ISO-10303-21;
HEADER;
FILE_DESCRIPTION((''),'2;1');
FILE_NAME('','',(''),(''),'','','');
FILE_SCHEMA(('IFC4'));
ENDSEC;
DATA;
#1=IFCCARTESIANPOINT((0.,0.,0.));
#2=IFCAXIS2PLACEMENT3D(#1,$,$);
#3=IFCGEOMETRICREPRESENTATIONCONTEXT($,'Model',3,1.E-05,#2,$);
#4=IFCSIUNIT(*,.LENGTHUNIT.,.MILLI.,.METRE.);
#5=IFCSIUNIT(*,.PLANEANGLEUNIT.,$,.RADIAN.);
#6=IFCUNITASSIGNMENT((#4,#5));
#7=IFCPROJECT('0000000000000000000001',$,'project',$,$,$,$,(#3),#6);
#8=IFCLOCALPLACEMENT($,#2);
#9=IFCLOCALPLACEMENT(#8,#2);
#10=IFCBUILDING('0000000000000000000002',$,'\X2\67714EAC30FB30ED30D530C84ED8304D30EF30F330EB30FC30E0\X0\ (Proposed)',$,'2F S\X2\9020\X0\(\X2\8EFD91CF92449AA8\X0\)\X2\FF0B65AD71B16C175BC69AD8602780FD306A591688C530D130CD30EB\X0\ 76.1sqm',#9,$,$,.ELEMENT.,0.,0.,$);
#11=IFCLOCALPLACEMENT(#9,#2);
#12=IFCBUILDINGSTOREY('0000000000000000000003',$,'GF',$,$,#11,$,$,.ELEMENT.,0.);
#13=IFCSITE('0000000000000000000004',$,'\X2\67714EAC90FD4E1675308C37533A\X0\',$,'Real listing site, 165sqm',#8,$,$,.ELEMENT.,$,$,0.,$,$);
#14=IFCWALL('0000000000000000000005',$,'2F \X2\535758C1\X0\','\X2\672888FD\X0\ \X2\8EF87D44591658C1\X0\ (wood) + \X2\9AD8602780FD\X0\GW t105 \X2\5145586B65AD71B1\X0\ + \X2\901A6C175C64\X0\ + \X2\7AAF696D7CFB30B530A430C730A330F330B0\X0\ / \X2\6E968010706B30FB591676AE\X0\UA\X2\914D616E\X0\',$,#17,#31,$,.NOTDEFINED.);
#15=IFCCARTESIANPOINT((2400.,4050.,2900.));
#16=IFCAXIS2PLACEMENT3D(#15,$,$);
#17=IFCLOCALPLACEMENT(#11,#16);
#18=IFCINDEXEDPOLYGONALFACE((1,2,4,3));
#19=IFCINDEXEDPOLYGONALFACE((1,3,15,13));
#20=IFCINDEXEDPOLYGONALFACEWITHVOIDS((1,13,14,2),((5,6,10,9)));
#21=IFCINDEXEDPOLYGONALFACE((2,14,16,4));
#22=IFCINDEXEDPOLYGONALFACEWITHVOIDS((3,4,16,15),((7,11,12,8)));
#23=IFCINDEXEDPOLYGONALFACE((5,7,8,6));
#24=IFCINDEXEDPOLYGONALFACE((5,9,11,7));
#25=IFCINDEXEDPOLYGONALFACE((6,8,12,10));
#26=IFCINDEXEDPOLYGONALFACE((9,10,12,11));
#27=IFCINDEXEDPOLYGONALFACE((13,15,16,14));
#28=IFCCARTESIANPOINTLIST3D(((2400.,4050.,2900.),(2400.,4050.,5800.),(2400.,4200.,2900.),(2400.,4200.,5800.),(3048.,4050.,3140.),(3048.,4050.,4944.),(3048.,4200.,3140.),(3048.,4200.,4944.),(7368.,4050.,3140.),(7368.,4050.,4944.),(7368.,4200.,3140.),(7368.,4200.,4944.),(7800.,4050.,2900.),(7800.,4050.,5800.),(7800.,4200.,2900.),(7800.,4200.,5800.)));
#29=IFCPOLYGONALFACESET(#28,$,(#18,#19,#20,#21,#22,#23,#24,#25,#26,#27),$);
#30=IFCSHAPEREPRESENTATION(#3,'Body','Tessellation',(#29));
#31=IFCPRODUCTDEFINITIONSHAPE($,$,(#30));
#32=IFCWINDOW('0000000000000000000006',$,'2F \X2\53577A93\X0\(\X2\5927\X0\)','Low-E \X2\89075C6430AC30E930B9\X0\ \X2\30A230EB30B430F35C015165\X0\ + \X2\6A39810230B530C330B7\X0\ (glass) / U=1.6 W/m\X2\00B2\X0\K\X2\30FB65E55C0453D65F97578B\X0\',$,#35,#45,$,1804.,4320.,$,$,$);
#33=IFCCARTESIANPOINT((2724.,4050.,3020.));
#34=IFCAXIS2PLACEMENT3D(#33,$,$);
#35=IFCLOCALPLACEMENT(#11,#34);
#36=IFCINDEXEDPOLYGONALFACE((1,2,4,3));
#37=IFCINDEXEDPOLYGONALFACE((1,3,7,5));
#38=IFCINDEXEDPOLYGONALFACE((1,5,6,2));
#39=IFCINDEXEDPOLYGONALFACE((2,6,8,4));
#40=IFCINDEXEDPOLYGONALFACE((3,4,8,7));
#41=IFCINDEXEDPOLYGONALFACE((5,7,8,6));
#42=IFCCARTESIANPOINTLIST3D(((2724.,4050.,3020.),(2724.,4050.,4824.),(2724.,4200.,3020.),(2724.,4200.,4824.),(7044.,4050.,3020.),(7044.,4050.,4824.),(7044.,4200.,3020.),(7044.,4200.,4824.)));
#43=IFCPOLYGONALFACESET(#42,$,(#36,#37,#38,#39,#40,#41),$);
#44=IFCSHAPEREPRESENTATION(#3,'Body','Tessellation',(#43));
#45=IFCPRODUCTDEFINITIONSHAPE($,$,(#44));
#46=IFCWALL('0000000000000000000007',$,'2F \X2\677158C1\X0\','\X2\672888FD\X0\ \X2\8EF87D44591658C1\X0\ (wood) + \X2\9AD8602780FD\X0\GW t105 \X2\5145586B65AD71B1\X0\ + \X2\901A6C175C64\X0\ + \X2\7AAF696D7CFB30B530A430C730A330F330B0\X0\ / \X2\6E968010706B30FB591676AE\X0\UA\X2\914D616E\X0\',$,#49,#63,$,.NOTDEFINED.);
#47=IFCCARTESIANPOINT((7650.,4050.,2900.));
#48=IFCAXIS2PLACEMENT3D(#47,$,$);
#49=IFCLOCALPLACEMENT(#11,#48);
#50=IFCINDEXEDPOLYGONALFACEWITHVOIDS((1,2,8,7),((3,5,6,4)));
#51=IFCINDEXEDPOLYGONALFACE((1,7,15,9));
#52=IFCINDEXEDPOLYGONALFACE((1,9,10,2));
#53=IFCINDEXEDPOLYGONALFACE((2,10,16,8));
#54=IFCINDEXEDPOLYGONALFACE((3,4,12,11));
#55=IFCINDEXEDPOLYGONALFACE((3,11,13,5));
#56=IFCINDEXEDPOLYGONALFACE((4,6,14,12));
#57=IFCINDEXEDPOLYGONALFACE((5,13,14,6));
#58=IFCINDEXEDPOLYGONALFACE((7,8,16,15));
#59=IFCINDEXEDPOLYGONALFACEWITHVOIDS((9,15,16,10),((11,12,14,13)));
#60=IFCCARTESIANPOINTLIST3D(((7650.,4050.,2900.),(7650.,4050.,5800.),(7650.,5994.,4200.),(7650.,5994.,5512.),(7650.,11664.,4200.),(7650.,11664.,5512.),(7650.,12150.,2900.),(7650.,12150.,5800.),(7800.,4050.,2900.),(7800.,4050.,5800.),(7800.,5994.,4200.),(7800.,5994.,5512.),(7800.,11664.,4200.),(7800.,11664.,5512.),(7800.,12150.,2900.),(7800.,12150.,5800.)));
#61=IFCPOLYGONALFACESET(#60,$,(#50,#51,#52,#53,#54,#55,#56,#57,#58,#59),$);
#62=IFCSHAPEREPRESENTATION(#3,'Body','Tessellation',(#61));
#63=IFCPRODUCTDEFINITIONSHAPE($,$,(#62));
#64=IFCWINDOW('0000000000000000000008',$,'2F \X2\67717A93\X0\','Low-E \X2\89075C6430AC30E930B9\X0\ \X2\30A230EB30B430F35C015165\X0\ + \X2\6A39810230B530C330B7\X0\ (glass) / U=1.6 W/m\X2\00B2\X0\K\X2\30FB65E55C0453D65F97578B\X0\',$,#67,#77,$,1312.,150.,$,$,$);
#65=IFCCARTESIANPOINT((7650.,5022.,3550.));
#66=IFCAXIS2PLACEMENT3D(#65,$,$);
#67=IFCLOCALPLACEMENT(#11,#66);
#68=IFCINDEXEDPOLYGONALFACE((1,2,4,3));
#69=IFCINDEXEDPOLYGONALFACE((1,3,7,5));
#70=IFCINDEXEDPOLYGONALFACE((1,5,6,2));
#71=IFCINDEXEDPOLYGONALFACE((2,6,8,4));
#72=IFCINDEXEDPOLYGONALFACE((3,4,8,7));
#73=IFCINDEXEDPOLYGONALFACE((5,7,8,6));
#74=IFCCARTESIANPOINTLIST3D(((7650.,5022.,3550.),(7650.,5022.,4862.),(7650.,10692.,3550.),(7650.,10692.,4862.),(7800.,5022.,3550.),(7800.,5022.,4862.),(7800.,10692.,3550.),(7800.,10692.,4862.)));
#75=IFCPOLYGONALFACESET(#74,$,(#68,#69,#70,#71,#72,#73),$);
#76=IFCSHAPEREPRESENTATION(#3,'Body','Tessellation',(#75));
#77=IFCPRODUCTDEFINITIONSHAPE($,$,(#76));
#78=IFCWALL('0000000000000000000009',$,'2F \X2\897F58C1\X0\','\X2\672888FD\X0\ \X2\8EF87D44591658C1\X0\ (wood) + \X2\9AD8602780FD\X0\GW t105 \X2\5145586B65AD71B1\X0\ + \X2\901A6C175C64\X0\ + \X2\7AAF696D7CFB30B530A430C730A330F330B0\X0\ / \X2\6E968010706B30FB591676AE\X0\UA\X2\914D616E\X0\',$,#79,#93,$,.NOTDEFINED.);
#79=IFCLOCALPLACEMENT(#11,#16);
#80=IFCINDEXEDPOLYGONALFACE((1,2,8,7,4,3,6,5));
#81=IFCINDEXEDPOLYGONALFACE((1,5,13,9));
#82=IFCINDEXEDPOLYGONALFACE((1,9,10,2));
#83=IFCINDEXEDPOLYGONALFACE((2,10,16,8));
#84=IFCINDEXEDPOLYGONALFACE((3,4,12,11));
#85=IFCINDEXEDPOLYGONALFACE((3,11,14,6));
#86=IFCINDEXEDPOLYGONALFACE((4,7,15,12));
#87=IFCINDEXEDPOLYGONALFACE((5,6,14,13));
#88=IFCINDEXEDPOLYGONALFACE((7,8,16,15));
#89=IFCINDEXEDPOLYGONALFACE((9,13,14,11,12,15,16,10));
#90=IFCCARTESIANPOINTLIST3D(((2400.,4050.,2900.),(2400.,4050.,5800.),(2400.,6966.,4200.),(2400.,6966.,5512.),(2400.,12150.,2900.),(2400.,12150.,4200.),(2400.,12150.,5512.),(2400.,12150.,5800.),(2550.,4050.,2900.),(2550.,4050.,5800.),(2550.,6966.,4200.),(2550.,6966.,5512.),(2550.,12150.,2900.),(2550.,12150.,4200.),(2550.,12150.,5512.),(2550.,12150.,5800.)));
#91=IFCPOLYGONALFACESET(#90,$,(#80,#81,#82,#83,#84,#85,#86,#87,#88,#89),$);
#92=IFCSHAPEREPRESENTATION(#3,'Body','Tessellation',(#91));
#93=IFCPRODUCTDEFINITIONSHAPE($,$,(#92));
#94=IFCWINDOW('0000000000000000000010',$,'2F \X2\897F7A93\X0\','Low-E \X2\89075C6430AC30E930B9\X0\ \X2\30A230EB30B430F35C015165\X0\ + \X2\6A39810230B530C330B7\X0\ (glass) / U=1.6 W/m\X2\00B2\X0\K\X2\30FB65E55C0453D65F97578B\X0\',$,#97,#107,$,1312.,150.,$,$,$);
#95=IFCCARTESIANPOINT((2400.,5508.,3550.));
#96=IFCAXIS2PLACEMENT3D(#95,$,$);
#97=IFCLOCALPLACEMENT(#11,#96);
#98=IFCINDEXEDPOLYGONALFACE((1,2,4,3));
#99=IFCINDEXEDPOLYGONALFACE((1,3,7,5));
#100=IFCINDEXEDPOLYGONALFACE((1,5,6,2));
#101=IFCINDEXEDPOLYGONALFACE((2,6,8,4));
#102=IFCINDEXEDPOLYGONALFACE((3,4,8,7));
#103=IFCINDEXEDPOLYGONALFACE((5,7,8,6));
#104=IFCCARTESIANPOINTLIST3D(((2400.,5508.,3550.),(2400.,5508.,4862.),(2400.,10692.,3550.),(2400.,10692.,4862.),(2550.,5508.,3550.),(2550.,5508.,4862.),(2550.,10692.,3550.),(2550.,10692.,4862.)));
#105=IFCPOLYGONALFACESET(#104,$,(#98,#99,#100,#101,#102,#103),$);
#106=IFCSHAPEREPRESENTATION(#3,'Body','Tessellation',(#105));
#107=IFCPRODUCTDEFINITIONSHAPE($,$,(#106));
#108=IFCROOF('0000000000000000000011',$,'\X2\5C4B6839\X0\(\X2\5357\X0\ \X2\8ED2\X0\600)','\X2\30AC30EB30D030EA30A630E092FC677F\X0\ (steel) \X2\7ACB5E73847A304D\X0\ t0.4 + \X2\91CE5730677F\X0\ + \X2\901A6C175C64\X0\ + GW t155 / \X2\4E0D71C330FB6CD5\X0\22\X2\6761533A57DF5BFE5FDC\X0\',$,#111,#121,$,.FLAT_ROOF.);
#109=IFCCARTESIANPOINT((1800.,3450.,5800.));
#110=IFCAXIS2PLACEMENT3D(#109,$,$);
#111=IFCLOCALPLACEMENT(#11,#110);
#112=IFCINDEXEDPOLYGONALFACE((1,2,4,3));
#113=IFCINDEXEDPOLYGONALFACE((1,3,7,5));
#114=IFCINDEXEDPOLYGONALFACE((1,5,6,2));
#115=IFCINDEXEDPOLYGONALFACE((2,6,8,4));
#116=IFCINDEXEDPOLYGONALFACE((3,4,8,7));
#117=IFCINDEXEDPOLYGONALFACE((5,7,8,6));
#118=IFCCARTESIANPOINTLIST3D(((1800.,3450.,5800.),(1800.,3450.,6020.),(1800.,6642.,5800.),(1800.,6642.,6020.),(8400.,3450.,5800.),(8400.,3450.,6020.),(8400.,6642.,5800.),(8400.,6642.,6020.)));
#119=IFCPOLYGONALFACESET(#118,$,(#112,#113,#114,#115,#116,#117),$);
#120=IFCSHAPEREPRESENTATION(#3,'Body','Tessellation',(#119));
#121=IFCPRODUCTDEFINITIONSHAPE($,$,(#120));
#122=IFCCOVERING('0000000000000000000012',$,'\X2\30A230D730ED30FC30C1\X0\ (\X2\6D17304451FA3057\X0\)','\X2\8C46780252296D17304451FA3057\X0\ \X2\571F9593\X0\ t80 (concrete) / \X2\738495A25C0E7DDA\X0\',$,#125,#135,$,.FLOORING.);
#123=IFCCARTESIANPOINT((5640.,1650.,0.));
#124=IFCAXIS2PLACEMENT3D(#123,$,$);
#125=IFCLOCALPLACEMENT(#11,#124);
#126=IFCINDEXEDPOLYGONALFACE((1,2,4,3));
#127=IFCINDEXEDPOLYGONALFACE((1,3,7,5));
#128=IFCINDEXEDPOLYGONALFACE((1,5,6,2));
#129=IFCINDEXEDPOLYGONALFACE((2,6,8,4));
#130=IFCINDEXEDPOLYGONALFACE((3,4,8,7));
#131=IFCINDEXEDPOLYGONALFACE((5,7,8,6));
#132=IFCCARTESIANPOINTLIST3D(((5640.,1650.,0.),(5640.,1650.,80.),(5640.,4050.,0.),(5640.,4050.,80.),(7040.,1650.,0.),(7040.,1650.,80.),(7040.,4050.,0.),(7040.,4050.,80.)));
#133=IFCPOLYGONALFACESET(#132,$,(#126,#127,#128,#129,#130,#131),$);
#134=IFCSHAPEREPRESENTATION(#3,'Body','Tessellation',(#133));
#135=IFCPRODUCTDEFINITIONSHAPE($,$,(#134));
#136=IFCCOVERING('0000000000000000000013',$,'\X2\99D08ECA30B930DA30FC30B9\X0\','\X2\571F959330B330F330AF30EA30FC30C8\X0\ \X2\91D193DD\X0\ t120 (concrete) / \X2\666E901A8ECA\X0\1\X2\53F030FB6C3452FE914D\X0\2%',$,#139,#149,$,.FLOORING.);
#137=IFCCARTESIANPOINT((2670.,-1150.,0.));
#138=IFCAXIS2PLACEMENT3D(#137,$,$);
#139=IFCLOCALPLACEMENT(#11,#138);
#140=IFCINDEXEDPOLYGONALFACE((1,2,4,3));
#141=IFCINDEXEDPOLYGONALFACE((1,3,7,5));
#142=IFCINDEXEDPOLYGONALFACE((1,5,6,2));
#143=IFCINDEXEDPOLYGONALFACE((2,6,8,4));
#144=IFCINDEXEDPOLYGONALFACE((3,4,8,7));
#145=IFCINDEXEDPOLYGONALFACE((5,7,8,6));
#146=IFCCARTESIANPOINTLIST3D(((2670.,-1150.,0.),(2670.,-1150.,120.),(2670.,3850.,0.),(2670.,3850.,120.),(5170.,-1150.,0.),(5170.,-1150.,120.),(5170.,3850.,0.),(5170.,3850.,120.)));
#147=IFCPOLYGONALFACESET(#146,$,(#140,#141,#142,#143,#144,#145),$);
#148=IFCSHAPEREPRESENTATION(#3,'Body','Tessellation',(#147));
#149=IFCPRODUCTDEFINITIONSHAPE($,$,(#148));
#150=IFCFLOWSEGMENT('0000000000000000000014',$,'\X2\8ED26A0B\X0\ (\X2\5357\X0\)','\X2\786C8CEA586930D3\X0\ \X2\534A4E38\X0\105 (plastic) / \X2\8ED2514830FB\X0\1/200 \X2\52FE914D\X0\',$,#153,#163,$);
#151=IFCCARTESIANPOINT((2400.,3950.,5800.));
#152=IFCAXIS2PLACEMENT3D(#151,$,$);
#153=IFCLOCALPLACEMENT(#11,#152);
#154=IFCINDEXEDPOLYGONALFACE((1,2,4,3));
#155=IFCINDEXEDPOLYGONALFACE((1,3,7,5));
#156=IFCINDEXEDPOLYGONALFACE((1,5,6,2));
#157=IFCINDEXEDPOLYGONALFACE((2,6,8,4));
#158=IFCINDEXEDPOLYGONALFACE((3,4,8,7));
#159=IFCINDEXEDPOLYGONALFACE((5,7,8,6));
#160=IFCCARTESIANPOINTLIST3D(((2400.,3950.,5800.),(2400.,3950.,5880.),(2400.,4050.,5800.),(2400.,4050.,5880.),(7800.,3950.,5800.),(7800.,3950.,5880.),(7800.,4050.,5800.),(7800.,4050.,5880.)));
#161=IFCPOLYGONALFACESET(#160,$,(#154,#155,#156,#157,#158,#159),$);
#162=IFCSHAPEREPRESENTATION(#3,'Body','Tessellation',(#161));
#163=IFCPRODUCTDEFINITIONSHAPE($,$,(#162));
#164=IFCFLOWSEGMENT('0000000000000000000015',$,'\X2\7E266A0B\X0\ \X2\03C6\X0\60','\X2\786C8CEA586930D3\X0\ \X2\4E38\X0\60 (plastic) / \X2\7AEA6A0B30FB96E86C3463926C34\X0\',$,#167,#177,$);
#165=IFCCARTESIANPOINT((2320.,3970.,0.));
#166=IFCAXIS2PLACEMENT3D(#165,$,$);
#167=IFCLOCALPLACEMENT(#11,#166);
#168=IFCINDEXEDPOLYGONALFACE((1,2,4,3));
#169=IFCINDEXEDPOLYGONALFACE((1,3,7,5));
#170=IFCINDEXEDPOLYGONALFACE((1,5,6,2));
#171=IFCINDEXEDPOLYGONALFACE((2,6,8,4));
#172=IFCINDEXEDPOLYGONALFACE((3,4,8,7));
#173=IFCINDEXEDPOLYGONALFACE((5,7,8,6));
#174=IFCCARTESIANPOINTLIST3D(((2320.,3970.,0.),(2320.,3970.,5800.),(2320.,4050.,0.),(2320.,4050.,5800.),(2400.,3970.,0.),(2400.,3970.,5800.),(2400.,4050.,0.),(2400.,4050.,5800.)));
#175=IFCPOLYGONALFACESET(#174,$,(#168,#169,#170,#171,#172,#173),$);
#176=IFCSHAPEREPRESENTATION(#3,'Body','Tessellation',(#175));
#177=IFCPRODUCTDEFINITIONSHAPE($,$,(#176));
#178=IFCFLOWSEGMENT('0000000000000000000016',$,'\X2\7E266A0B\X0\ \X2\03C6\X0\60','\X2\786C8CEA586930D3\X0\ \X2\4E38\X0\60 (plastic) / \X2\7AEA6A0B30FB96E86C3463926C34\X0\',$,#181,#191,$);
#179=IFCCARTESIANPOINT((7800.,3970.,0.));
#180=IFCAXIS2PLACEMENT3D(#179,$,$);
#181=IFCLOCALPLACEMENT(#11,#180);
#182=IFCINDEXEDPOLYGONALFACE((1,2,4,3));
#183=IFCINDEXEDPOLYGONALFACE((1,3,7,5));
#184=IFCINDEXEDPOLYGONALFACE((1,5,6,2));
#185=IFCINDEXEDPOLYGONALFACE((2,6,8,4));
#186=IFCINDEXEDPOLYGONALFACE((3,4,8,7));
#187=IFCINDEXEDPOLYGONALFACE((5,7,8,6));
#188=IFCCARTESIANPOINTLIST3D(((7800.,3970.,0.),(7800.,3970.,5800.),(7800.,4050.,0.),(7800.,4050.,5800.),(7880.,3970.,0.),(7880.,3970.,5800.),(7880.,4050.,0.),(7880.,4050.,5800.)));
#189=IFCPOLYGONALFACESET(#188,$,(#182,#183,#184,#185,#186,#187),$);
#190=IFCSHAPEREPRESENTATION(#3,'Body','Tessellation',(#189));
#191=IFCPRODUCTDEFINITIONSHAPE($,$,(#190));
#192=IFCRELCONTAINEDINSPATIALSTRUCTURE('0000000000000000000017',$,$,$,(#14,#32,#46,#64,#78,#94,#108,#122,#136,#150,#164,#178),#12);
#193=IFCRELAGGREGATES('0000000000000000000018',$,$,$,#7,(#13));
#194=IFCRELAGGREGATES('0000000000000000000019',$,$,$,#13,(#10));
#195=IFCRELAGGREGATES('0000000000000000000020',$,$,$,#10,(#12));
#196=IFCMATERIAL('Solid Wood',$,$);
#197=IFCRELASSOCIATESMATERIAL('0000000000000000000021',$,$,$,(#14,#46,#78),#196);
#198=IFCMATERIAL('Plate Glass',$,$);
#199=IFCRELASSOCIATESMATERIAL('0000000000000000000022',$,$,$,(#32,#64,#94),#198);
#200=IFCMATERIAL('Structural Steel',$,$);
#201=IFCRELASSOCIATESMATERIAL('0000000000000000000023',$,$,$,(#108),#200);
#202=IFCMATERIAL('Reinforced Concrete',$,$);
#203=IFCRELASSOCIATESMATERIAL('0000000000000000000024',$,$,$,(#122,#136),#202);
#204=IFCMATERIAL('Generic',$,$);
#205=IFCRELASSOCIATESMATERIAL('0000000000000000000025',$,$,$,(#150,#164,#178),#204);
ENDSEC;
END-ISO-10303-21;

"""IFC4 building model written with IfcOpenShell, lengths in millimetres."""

from ifc_helpers import new_model, si_unit, frame, frame_2d, origin, place, context, project, spatial, rectangle, extrude, material, element, fill, save


model = new_model("IFC4")

# Units and contexts
model_context = context("Model", 3, precision=1e-05, world=origin())
ifc_project = project(units=[si_unit("LENGTHUNIT", "METRE", prefix="MILLI"), si_unit("PLANEANGLEUNIT", "RADIAN")], contexts=[model_context])

# Site, building, storey
site_placement = place(None, origin())
site = spatial("IfcSite", under=ifc_project, at=site_placement, Name="東京都世田谷区", ObjectType="Real listing site, 165sqm", CompositionType="ELEMENT", RefElevation=0.0)
building_placement = place(site_placement, origin())
building = spatial("IfcBuilding", under=site, at=building_placement, Name="東京・ロフト付きワンルーム (Proposed)", ObjectType="2F S造(軽量鉄骨)＋断熱気密高性能な外装パネル 76.1sqm", CompositionType="ELEMENT", ElevationOfRefHeight=0.0, ElevationOfTerrain=0.0)
storey_placement = place(building_placement, origin())
storey = spatial("IfcBuildingStorey", under=building, at=storey_placement, Name="GF", CompositionType="ELEMENT", Elevation=0.0)

# Shared definitions
ifc_material_1 = material(Name="Solid Wood")

# Shared definitions
ifc_material_2 = material(Name="Reinforced Concrete")

# Shared definitions
ifc_material_3 = material(Name="Plate Glass")

# Walls, openings, windows
wall_1_placement = place(storey_placement, frame((2400.0, 4050.0, 2900.0)))
wall_1 = element("IfcWall", 1, at=wall_1_placement, inside=storey, material=ifc_material_1, Name="2F 南壁", Description="木製 軸組外壁 (wood) + 高性能GW t105 充填断熱 + 通気層 + 窯業系サイディング / 準耐火・外皮UA配慮", PredefinedType="NOTDEFINED", context=model_context, shape_type="SweptSolid", body=[
    extrude(rectangle(XDim=5400.0, YDim=150.0, at=frame_2d((2700.0, 75.0))), frame((2400.0, 4050.0, 2900.0)), (0.0, 0.0, 1.0), 2900.0),
])
opening_1_placement = place(storey_placement, frame((2724.0, 4050.0, 3020.0)))
opening_1 = element("IfcOpeningElement", 2, at=opening_1_placement, cuts=wall_1, PredefinedType="NOTDEFINED", context=model_context, shape_type="SweptSolid", body=[
    extrude(rectangle(XDim=4320.0, YDim=150.0, at=frame_2d((2160.0, 75.0))), frame((2724.0, 4050.0, 3020.0)), (0.0, 0.0, 1.0), 1804.0),
])
window_1_placement = place(storey_placement, frame((2724.0, 4050.0, 3020.0)))
window_1 = element("IfcWindow", 3, at=window_1_placement, inside=storey, material=ifc_material_3, Name="2F 南窓(大)", Description="Low-E 複層ガラス アルゴン封入 + 樹脂サッシ (glass) / U=1.6 W/m²K・日射取得型", OverallHeight=1804.0, OverallWidth=4320.0, context=model_context, shape_type="SweptSolid", body=[
    extrude(rectangle(XDim=4320.0, YDim=150.0, at=frame_2d((2160.0, 75.0))), frame((2724.0, 4050.0, 3020.0)), (0.0, 0.0, 1.0), 1804.0),
])
fill(opening_1, window_1)
wall_2_placement = place(storey_placement, frame((7650.0, 4050.0, 2900.0)))
wall_2 = element("IfcWall", 4, at=wall_2_placement, inside=storey, material=ifc_material_1, Name="2F 東壁", Description="木製 軸組外壁 (wood) + 高性能GW t105 充填断熱 + 通気層 + 窯業系サイディング / 準耐火・外皮UA配慮", PredefinedType="NOTDEFINED", context=model_context, shape_type="SweptSolid", body=[
    extrude(rectangle(XDim=150.0, YDim=8100.0, at=frame_2d((75.0, 4050.0))), frame((7650.0, 4050.0, 2900.0)), (0.0, 0.0, 1.0), 2900.0),
])
opening_2_placement = place(storey_placement, frame((7650.0, 5022.0, 3550.0)))
opening_2 = element("IfcOpeningElement", 5, at=opening_2_placement, cuts=wall_2, PredefinedType="NOTDEFINED", context=model_context, shape_type="SweptSolid", body=[
    extrude(rectangle(XDim=150.0, YDim=5670.0, at=frame_2d((75.0, 2835.0))), frame((7650.0, 5022.0, 3550.0)), (0.0, 0.0, 1.0), 1312.0),
])
window_2_placement = place(storey_placement, frame((7650.0, 5022.0, 3550.0)))
window_2 = element("IfcWindow", 6, at=window_2_placement, inside=storey, material=ifc_material_3, Name="2F 東窓", Description="Low-E 複層ガラス アルゴン封入 + 樹脂サッシ (glass) / U=1.6 W/m²K・日射取得型", OverallHeight=1312.0, OverallWidth=150.0, context=model_context, shape_type="SweptSolid", body=[
    extrude(rectangle(XDim=150.0, YDim=5670.0, at=frame_2d((75.0, 2835.0))), frame((7650.0, 5022.0, 3550.0)), (0.0, 0.0, 1.0), 1312.0),
])
fill(opening_2, window_2)
wall_3_placement = place(storey_placement, frame((2400.0, 4050.0, 2900.0)))
wall_3 = element("IfcWall", 7, at=wall_3_placement, inside=storey, material=ifc_material_1, Name="2F 西壁", Description="木製 軸組外壁 (wood) + 高性能GW t105 充填断熱 + 通気層 + 窯業系サイディング / 準耐火・外皮UA配慮", PredefinedType="NOTDEFINED", context=model_context, shape_type="SweptSolid", body=[
    extrude(rectangle(XDim=150.0, YDim=8100.0, at=frame_2d((75.0, 4050.0))), frame((2400.0, 4050.0, 2900.0)), (0.0, 0.0, 1.0), 2900.0),
])
opening_3_placement = place(storey_placement, frame((2400.0, 5508.0, 3550.0)))
opening_3 = element("IfcOpeningElement", 8, at=opening_3_placement, cuts=wall_3, PredefinedType="NOTDEFINED", context=model_context, shape_type="SweptSolid", body=[
    extrude(rectangle(XDim=150.0, YDim=5184.0, at=frame_2d((75.0, 2592.0))), frame((2400.0, 5508.0, 3550.0)), (0.0, 0.0, 1.0), 1312.0),
])
window_3_placement = place(storey_placement, frame((2400.0, 5508.0, 3550.0)))
window_3 = element("IfcWindow", 9, at=window_3_placement, inside=storey, material=ifc_material_3, Name="2F 西窓", Description="Low-E 複層ガラス アルゴン封入 + 樹脂サッシ (glass) / U=1.6 W/m²K・日射取得型", OverallHeight=1312.0, OverallWidth=150.0, context=model_context, shape_type="SweptSolid", body=[
    extrude(rectangle(XDim=150.0, YDim=5184.0, at=frame_2d((75.0, 2592.0))), frame((2400.0, 5508.0, 3550.0)), (0.0, 0.0, 1.0), 1312.0),
])
fill(opening_3, window_3)

# Roof
ifc_material_4 = material(Name="Structural Steel")
for number, where, name in (
    (10, (1800.0, 3450.0, 5800.0), "屋根(南 軒600)"),
):
    element("IfcRoof", number, at=place(storey_placement, frame(where)), inside=storey, material=ifc_material_4, Name=name, Description="ガルバリウム鋼板 (steel) 立平葺き t0.4 + 野地板 + 通気層 + GW t155 / 不燃・法22条区域対応", PredefinedType="FLAT_ROOF", context=model_context, shape_type="SweptSolid", body=[
        extrude(rectangle(XDim=6600.0, YDim=3192.0, at=frame_2d((3300.0, 1596.0))), frame((1800.0, 3450.0, 5800.0)), (0.0, 0.0, 1.0), 220.0),
    ])

# Coverings
covering_1_placement = place(storey_placement, frame((5640.0, 1650.0, 0.0)))
element("IfcCovering", 11, at=covering_1_placement, inside=storey, material=ifc_material_2, Name="アプローチ (洗い出し)", Description="豆砂利洗い出し 土間 t80 (concrete) / 玄関導線", PredefinedType="FLOORING", context=model_context, shape_type="SweptSolid", body=[
    extrude(rectangle(XDim=1400.0, YDim=2400.0, at=frame_2d((700.0, 1200.0))), frame((5640.0, 1650.0, 0.0)), (0.0, 0.0, 1.0), 80.0),
])
covering_2_placement = place(storey_placement, frame((2670.0, -1150.0, 0.0)))
element("IfcCovering", 12, at=covering_2_placement, inside=storey, material=ifc_material_2, Name="駐車スペース", Description="土間コンクリート 金鏝 t120 (concrete) / 普通車1台・水勾配2%", PredefinedType="FLOORING", context=model_context, shape_type="SweptSolid", body=[
    extrude(rectangle(XDim=2500.0, YDim=5000.0, at=frame_2d((1250.0, 2500.0))), frame((2670.0, -1150.0, 0.0)), (0.0, 0.0, 1.0), 120.0),
])

# Flow segments
ifc_material_5 = material(Name="Generic")
flow_segment_1_placement = place(storey_placement, frame((2400.0, 3950.0, 5800.0)))
element("IfcFlowSegment", 13, at=flow_segment_1_placement, inside=storey, material=ifc_material_5, Name="軒樋 (南)", Description="硬質塩ビ 半丸105 (plastic) / 軒先・1/200 勾配", context=model_context, shape_type="SweptSolid", body=[
    extrude(rectangle(XDim=5400.0, YDim=100.0, at=frame_2d((2700.0, 50.0))), frame((2400.0, 3950.0, 5800.0)), (0.0, 0.0, 1.0), 80.0),
])
flow_segment_2_placement = place(storey_placement, frame((2320.0, 3970.0, 0.0)))
element("IfcFlowSegment", 14, at=flow_segment_2_placement, inside=storey, material=ifc_material_5, Name="縦樋 φ60", Description="硬質塩ビ 丸60 (plastic) / 竪樋・雨水排水", context=model_context, shape_type="SweptSolid", body=[
    extrude(rectangle(XDim=80.0, YDim=80.0, at=frame_2d((40.0, 40.0))), frame((2320.0, 3970.0, 0.0)), (0.0, 0.0, 1.0), 5800.0),
])
flow_segment_3_placement = place(storey_placement, frame((7800.0, 3970.0, 0.0)))
element("IfcFlowSegment", 15, at=flow_segment_3_placement, inside=storey, material=ifc_material_5, Name="縦樋 φ60", Description="硬質塩ビ 丸60 (plastic) / 竪樋・雨水排水", context=model_context, shape_type="SweptSolid", body=[
    extrude(rectangle(XDim=80.0, YDim=80.0, at=frame_2d((40.0, 40.0))), frame((7800.0, 3970.0, 0.0)), (0.0, 0.0, 1.0), 5800.0),
])

save(model, "model.ifc")
